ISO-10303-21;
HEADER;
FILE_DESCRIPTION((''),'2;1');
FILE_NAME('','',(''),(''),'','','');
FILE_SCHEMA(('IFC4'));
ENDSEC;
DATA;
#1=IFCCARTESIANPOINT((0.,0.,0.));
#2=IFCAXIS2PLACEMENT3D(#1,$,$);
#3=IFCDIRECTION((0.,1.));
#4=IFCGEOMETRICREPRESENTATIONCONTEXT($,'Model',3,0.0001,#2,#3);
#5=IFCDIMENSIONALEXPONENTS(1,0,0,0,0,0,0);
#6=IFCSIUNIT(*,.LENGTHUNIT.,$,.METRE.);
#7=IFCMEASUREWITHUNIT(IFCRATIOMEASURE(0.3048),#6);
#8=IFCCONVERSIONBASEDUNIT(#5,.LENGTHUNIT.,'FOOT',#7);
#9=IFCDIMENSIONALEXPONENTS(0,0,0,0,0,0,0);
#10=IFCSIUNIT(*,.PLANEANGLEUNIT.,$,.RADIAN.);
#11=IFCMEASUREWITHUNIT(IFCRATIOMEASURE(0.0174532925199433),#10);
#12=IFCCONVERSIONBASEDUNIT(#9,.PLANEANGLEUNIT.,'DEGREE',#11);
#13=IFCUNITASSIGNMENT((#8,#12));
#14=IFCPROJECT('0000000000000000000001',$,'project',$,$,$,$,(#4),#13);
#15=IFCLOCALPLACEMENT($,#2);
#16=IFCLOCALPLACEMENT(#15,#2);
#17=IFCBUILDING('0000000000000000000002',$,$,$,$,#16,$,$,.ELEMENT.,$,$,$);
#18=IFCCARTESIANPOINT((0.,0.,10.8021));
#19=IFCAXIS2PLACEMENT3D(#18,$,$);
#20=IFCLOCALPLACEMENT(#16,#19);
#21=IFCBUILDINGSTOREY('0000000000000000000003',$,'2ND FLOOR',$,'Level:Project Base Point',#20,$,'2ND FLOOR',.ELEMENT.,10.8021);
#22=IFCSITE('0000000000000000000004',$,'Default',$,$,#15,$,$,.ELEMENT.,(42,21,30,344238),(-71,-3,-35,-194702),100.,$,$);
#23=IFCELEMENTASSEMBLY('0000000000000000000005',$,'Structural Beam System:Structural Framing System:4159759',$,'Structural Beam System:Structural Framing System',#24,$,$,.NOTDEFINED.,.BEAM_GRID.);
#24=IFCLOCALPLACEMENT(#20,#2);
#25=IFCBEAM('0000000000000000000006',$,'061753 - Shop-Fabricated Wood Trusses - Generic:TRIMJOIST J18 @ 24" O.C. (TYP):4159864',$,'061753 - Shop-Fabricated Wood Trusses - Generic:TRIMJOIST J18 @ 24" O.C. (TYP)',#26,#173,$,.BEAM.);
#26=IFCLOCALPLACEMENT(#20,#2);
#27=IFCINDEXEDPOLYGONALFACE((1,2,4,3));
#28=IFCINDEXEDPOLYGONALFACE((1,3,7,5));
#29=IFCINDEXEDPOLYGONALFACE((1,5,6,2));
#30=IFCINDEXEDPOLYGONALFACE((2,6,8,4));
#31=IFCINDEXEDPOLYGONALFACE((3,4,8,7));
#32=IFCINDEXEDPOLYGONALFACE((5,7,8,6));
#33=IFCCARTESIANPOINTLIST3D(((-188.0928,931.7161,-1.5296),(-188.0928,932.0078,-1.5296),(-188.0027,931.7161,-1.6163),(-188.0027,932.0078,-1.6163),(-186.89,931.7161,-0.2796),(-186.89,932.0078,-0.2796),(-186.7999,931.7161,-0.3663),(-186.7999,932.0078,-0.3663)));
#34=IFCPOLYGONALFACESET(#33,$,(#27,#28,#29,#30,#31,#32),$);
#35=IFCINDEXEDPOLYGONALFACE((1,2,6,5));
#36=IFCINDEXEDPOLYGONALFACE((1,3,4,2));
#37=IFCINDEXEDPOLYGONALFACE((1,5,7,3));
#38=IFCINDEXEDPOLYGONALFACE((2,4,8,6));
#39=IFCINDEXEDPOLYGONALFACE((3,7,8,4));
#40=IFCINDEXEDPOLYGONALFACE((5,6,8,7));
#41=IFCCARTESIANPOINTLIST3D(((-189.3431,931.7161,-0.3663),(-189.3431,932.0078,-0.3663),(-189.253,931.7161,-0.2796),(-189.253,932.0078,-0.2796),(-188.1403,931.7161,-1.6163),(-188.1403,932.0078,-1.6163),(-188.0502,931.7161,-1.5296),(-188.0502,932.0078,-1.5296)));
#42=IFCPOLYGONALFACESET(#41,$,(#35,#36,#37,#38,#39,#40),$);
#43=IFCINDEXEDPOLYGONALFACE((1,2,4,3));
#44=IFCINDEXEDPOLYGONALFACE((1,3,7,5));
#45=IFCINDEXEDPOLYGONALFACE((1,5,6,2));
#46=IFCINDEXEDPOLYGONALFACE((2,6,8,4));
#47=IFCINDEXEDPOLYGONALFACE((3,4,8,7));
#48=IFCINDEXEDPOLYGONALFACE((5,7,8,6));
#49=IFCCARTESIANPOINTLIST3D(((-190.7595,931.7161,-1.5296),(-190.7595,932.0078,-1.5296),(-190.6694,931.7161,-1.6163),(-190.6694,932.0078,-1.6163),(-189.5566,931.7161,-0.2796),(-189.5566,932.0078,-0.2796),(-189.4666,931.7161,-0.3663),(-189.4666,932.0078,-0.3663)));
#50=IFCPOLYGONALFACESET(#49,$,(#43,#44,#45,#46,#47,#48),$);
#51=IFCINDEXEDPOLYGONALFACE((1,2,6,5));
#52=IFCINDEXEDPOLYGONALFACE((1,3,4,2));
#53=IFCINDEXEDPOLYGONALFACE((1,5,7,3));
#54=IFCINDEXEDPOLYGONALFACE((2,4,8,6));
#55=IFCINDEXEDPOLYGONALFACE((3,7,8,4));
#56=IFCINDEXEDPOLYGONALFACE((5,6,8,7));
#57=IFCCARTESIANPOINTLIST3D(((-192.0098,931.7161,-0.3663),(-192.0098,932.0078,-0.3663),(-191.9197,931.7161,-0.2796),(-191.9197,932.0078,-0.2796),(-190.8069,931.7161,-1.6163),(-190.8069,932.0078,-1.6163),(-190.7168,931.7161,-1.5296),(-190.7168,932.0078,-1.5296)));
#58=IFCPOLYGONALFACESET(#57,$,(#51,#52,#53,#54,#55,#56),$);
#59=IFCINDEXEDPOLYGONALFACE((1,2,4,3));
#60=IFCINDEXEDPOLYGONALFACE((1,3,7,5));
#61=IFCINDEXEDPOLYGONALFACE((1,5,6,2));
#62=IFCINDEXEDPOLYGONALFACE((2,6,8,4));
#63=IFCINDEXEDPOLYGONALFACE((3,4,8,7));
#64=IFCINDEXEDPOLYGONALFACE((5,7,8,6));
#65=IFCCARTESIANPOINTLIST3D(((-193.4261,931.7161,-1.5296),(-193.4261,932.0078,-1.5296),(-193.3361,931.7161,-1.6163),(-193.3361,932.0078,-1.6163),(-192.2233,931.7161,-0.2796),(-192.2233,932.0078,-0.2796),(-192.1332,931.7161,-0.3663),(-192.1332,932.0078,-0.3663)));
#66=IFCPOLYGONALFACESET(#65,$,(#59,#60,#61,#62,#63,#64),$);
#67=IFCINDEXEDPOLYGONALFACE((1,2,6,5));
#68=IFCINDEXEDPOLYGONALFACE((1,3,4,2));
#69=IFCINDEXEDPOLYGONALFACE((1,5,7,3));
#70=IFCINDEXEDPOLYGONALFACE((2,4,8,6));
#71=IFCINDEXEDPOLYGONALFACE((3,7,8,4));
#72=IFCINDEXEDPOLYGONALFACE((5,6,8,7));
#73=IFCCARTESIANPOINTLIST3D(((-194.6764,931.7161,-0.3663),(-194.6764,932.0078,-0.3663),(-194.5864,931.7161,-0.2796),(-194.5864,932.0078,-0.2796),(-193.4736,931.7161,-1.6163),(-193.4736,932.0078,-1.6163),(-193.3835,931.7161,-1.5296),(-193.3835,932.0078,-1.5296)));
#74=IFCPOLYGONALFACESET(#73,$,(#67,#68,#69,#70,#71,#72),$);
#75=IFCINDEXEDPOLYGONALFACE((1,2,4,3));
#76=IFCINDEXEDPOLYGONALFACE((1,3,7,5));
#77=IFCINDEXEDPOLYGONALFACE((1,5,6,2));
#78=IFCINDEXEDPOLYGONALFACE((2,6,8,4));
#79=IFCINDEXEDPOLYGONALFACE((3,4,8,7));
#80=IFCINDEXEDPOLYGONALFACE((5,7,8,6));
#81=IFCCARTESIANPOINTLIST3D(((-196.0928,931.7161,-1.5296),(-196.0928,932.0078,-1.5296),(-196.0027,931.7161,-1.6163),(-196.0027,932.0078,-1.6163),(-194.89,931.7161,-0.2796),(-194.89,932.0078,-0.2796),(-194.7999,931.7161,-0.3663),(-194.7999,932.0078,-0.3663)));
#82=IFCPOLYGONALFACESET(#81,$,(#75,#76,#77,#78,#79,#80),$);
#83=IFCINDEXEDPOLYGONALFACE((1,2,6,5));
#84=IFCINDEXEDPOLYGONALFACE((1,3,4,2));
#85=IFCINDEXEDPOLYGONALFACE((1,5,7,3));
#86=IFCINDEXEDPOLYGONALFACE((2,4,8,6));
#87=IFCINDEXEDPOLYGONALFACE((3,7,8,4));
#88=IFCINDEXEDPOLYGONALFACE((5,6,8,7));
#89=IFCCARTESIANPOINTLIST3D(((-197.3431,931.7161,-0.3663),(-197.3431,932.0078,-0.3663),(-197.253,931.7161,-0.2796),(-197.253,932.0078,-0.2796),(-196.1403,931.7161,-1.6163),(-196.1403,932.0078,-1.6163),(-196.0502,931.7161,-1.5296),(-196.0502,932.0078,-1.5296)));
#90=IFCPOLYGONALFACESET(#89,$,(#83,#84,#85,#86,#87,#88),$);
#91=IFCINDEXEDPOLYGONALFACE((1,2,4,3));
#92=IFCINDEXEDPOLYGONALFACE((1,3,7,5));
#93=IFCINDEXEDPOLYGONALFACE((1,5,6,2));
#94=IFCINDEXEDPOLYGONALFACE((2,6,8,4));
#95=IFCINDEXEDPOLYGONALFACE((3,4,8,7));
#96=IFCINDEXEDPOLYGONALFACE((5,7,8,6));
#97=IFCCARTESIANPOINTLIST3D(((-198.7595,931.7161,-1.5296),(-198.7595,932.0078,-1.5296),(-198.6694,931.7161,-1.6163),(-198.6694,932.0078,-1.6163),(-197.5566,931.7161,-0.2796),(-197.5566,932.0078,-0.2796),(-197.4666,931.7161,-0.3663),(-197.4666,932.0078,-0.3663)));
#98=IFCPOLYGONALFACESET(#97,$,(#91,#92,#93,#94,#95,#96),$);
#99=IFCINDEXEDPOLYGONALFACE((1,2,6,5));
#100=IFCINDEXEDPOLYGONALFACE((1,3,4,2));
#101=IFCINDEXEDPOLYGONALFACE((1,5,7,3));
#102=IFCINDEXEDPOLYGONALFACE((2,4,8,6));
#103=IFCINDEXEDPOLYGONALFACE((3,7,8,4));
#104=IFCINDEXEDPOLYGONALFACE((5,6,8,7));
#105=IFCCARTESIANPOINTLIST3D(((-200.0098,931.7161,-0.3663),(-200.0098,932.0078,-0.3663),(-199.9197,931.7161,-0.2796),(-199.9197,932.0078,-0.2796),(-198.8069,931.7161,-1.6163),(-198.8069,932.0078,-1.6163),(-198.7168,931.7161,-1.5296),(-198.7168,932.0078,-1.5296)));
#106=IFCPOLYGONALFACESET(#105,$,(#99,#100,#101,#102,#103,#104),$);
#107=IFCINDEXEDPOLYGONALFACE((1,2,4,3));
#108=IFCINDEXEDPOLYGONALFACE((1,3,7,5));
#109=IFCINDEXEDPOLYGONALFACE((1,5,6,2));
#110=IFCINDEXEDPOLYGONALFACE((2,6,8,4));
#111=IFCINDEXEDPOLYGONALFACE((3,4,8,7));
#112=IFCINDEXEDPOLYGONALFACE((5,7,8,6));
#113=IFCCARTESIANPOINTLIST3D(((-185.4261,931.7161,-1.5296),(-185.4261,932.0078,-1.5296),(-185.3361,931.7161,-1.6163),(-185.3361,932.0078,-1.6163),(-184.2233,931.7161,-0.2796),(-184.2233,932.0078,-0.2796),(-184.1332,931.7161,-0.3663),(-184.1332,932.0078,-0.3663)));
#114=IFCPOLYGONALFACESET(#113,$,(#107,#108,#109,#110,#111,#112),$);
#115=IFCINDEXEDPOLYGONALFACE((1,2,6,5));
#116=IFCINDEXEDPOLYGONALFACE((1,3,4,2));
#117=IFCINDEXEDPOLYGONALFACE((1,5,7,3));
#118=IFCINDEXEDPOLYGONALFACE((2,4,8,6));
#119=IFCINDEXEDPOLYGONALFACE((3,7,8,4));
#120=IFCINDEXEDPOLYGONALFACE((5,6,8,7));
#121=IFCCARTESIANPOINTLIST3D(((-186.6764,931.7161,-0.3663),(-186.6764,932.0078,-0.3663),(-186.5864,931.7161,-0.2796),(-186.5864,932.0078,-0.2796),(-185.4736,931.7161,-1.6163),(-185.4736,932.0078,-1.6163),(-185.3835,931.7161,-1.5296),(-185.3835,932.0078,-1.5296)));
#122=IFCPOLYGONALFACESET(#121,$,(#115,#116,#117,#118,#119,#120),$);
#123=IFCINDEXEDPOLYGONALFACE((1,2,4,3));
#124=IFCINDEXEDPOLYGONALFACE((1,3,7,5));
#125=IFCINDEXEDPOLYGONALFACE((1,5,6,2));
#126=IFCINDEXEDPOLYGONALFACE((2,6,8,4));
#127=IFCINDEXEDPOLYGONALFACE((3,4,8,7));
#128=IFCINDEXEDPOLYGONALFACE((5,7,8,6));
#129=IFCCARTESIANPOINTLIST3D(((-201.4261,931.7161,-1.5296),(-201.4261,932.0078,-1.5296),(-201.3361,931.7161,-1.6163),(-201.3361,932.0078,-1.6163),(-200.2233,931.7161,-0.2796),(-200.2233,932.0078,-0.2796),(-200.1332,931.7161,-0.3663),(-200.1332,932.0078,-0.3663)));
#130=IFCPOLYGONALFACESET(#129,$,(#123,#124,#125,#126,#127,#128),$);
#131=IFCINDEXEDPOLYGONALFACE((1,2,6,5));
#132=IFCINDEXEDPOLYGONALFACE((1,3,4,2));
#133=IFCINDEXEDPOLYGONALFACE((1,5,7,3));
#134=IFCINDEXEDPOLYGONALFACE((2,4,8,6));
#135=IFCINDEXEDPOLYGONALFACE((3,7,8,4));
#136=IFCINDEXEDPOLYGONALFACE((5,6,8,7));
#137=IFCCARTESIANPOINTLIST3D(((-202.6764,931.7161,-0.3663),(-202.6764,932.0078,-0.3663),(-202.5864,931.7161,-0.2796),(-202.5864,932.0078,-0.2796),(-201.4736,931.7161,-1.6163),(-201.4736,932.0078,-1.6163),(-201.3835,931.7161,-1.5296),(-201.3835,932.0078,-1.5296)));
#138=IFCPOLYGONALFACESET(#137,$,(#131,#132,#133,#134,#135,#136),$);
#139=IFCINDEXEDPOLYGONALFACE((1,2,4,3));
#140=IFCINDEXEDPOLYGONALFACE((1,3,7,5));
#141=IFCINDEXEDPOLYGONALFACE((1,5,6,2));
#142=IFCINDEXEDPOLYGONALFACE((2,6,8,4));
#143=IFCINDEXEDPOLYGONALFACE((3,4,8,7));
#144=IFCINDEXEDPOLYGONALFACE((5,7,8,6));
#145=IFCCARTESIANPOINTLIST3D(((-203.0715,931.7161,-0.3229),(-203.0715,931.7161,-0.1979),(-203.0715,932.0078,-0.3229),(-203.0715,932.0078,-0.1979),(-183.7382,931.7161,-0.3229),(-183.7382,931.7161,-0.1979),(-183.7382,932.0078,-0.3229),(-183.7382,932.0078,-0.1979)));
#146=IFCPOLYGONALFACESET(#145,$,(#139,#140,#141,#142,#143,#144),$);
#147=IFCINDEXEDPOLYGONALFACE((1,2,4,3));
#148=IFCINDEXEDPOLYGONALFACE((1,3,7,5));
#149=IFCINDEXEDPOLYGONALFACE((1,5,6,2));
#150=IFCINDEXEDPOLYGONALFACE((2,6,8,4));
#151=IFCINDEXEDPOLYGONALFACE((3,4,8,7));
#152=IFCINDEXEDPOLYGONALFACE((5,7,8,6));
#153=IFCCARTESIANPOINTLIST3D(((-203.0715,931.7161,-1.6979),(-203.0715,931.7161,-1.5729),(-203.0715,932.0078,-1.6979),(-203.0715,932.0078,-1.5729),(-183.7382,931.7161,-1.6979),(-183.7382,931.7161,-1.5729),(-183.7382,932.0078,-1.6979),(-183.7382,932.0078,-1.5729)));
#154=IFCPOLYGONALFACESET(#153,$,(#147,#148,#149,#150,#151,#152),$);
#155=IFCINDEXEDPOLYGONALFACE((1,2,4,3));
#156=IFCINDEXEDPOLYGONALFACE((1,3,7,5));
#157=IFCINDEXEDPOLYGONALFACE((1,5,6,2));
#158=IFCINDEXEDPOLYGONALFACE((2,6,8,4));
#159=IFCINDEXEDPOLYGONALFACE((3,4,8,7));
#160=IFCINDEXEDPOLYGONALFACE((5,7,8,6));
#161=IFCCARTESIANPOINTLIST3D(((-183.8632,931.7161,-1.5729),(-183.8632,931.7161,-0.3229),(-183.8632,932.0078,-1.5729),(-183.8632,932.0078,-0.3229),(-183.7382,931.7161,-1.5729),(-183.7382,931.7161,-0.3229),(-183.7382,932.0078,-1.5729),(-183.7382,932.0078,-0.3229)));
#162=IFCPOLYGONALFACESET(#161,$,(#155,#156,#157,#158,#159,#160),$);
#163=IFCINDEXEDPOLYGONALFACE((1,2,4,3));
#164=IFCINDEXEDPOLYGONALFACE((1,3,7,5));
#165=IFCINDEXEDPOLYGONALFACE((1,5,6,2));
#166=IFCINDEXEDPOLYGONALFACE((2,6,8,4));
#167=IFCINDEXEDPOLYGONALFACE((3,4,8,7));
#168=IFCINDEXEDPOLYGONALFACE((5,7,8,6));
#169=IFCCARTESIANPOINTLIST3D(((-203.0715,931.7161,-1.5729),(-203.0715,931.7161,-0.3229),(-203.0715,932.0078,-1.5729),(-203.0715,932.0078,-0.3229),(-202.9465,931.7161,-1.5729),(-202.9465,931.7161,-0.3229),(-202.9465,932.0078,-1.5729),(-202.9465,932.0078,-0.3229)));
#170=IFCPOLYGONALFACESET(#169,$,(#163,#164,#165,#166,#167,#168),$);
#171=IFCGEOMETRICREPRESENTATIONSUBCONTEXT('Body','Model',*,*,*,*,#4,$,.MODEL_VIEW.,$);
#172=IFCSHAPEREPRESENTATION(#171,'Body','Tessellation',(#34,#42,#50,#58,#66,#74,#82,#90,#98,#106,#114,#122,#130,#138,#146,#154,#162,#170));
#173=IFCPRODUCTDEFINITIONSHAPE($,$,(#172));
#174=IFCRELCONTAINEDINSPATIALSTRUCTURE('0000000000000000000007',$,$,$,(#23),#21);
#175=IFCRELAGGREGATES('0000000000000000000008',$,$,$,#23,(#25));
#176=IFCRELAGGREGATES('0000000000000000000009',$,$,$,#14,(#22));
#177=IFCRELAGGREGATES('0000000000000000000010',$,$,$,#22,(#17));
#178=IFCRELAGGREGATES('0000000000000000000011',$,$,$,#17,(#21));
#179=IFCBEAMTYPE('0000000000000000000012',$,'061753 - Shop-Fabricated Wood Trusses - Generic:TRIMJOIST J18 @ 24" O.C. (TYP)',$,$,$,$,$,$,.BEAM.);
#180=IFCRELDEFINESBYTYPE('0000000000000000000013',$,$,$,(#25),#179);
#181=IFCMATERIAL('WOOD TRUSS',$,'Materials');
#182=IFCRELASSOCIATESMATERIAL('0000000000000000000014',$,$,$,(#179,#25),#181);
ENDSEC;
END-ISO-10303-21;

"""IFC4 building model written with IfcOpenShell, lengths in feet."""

from ifc_helpers import new_model, entity, si_unit, converted_unit, direction, frame, frame_2d, origin, origin_2d_with_axis, place, context, subcontext, project, spatial, rectangle, extrude, source, transform, mapped, material, material_profile, profile_set, profile_usage, type_object, type_shapes, element, aggregate, save


model = new_model("IFC4")

# Units and contexts
model_context = context("Model", 3, precision=0.0001, world=origin(), true_north=direction((0.0, 1.0)))
body_context = subcontext(model_context, "Body", "Model", "MODEL_VIEW")
ifc_project = project(units=[converted_unit("LENGTHUNIT", "FOOT", entity("IfcRatioMeasure", 0.3048), si_unit("LENGTHUNIT", "METRE"), dimensions=[1, 0, 0, 0, 0, 0, 0]), converted_unit("PLANEANGLEUNIT", "DEGREE", entity("IfcRatioMeasure", 0.0174532925199433), si_unit("PLANEANGLEUNIT", "RADIAN"), dimensions=[0, 0, 0, 0, 0, 0, 0])], contexts=[model_context])

# Site, building, storey
site_placement = place(None, origin())
site = spatial("IfcSite", under=ifc_project, at=site_placement, Name="Default", CompositionType="ELEMENT", RefLatitude=(42, 21, 30, 344238), RefLongitude=(-71, -3, -35, -194702), RefElevation=100.0)
building_placement = place(site_placement, origin())
building = spatial("IfcBuilding", under=site, at=building_placement, CompositionType="ELEMENT")
storey_placement = place(building_placement, frame((0.0, 0.0, 10.8021)))
storey = spatial("IfcBuildingStorey", under=building, at=storey_placement, Name="2ND FLOOR", ObjectType="Level:Project Base Point", LongName="2ND FLOOR", CompositionType="ELEMENT", Elevation=10.8021)

# Element assembly, beam
ifc_material_1 = material(Name="WOOD TRUSS", Category="Materials")
ifc_material_profile_1 = material_profile(ifc_material_1, rectangle(XDim=1.7347, YDim=0.125, at=frame_2d((0.0, 0.0), x_axis=(1.0, 0.0))), Name="TRIMJOIST J18 @ 24\" O.C. (TYP)")
ifc_material_profile_2 = material_profile(ifc_material_1, rectangle(XDim=1.7347, YDim=0.125, at=frame_2d((0.0, 0.0), x_axis=(1.0, 0.0))), Name="TRIMJOIST J18 @ 24\" O.C. (TYP)")
ifc_material_profile_3 = material_profile(ifc_material_1, rectangle(XDim=1.7347, YDim=0.125, at=frame_2d((0.0, 0.0), x_axis=(1.0, 0.0))), Name="TRIMJOIST J18 @ 24\" O.C. (TYP)")
ifc_material_profile_4 = material_profile(ifc_material_1, rectangle(XDim=1.7347, YDim=0.125, at=frame_2d((0.0, 0.0), x_axis=(1.0, 0.0))), Name="TRIMJOIST J18 @ 24\" O.C. (TYP)")
ifc_material_profile_5 = material_profile(ifc_material_1, rectangle(XDim=1.7347, YDim=0.125, at=frame_2d((0.0, 0.0), x_axis=(1.0, 0.0))), Name="TRIMJOIST J18 @ 24\" O.C. (TYP)")
ifc_material_profile_6 = material_profile(ifc_material_1, rectangle(XDim=1.7347, YDim=0.125, at=frame_2d((0.0, 0.0), x_axis=(1.0, 0.0))), Name="TRIMJOIST J18 @ 24\" O.C. (TYP)")
ifc_material_profile_7 = material_profile(ifc_material_1, rectangle(XDim=1.7347, YDim=0.125, at=frame_2d((0.0, 0.0), x_axis=(1.0, 0.0))), Name="TRIMJOIST J18 @ 24\" O.C. (TYP)")
ifc_material_profile_8 = material_profile(ifc_material_1, rectangle(XDim=1.7347, YDim=0.125, at=frame_2d((0.0, 0.0), x_axis=(1.0, 0.0))), Name="TRIMJOIST J18 @ 24\" O.C. (TYP)")
ifc_material_profile_9 = material_profile(ifc_material_1, rectangle(XDim=1.7347, YDim=0.125, at=frame_2d((0.0, 0.0), x_axis=(1.0, 0.0))), Name="TRIMJOIST J18 @ 24\" O.C. (TYP)")
ifc_material_profile_10 = material_profile(ifc_material_1, rectangle(XDim=1.7347, YDim=0.125, at=origin_2d_with_axis()), Name="TRIMJOIST J18 @ 24\" O.C. (TYP)")
ifc_material_profile_11 = material_profile(ifc_material_1, rectangle(XDim=0.125, YDim=0.2917, at=origin_2d_with_axis()), Name="TRIMJOIST J18 @ 24\" O.C. (TYP)")
ifc_material_profile_12 = material_profile(ifc_material_1, rectangle(XDim=0.125, YDim=0.2917, at=origin_2d_with_axis()), Name="TRIMJOIST J18 @ 24\" O.C. (TYP)")
ifc_material_profile_13 = material_profile(ifc_material_1, rectangle(XDim=1.25, YDim=0.2917, at=origin_2d_with_axis()), Name="TRIMJOIST J18 @ 24\" O.C. (TYP)")
ifc_material_profile_14 = material_profile(ifc_material_1, rectangle(XDim=1.25, YDim=0.2917, at=origin_2d_with_axis()), Name="TRIMJOIST J18 @ 24\" O.C. (TYP)")
ifc_profile_set_1 = profile_set([ifc_material_profile_1, ifc_material_profile_2, ifc_material_profile_3, ifc_material_profile_4, ifc_material_profile_5, ifc_material_profile_6, ifc_material_profile_7, ifc_material_profile_8, ifc_material_profile_9, ifc_material_profile_10, ifc_material_profile_11, ifc_material_profile_12, ifc_material_profile_13, ifc_material_profile_14], Name="TRIMJOIST J18 @ 24\" O.C. (TYP)")
beam_type_1 = type_object("IfcBeamType", Name="061753 - Shop-Fabricated Wood Trusses - Generic:TRIMJOIST J18 @ 24\" O.C. (TYP)", PredefinedType="BEAM", material=ifc_profile_set_1)
shared_shape_1 = source(origin(), body_context, "Body", "SweptSolid", [
    extrude(rectangle(XDim=1.7347, YDim=0.125, at=frame_2d((0.0, 0.0), x_axis=(1.0, 0.0))), frame((5.9585, -0.1458, 0.0), z_axis=(0.0, 1.0, 0.0), x_axis=(0.693383, 0.0, 0.720569)), (0.0, 0.0, 1.0), 0.2917),
    extrude(rectangle(XDim=1.7347, YDim=0.125, at=origin_2d_with_axis()), frame((4.7082, -0.1458, 0.0), z_axis=(0.0, 1.0, 0.0), x_axis=(0.693383, 0.0, -0.720569)), (0.0, 0.0, 1.0), 0.2917),
    extrude(rectangle(XDim=1.7347, YDim=0.125, at=frame_2d((0.0, 0.0), x_axis=(1.0, 0.0))), frame((3.2918, -0.1458, 0.0), z_axis=(0.0, 1.0, 0.0), x_axis=(0.693383, 0.0, 0.720569)), (0.0, 0.0, 1.0), 0.2917),
    extrude(rectangle(XDim=1.7347, YDim=0.125, at=frame_2d((0.0, 0.0), x_axis=(1.0, 0.0))), frame((2.0415, -0.1458, 0.0), z_axis=(0.0, 1.0, 0.0), x_axis=(0.693383, 0.0, -0.720569)), (0.0, 0.0, 1.0), 0.2917),
    extrude(rectangle(XDim=1.7347, YDim=0.125, at=frame_2d((0.0, 0.0), x_axis=(1.0, 0.0))), frame((0.6251, -0.1458, 0.0), z_axis=(0.0, 1.0, 0.0), x_axis=(0.693383, 0.0, 0.720569)), (0.0, 0.0, 1.0), 0.2917),
    extrude(rectangle(XDim=1.7347, YDim=0.125, at=frame_2d((0.0, 0.0), x_axis=(1.0, 0.0))), frame((-0.6251, -0.1458, 0.0), z_axis=(0.0, 1.0, 0.0), x_axis=(0.693383, 0.0, -0.720569)), (0.0, 0.0, 1.0), 0.2917),
    extrude(rectangle(XDim=1.7347, YDim=0.125, at=frame_2d((0.0, 0.0), x_axis=(1.0, 0.0))), frame((-2.0415, -0.1458, 0.0), z_axis=(0.0, 1.0, 0.0), x_axis=(0.693383, 0.0, 0.720569)), (0.0, 0.0, 1.0), 0.2917),
    extrude(rectangle(XDim=1.7347, YDim=0.125, at=origin_2d_with_axis()), frame((-3.2918, -0.1458, 0.0), z_axis=(0.0, 1.0, 0.0), x_axis=(0.693383, 0.0, -0.720569)), (0.0, 0.0, 1.0), 0.2917),
    extrude(rectangle(XDim=1.7347, YDim=0.125, at=frame_2d((0.0, 0.0), x_axis=(1.0, 0.0))), frame((-4.7082, -0.1458, 0.0), z_axis=(0.0, 1.0, 0.0), x_axis=(0.693383, 0.0, 0.720569)), (0.0, 0.0, 1.0), 0.2917),
    extrude(rectangle(XDim=1.7347, YDim=0.125, at=frame_2d((0.0, 0.0), x_axis=(1.0, 0.0))), frame((-5.9585, -0.1458, 0.0), z_axis=(0.0, 1.0, 0.0), x_axis=(0.693383, 0.0, -0.720569)), (0.0, 0.0, 1.0), 0.2917),
    extrude(rectangle(XDim=1.7347, YDim=0.125, at=frame_2d((0.0, 0.0), x_axis=(1.0, 0.0))), frame((8.6251, -0.1458, 0.0), z_axis=(0.0, 1.0, 0.0), x_axis=(0.693383, 0.0, 0.720569)), (0.0, 0.0, 1.0), 0.2917),
    extrude(rectangle(XDim=1.7347, YDim=0.125, at=origin_2d_with_axis()), frame((7.3749, -0.1458, 0.0), z_axis=(0.0, 1.0, 0.0), x_axis=(0.693383, 0.0, -0.720569)), (0.0, 0.0, 1.0), 0.2917),
    extrude(rectangle(XDim=1.7347, YDim=0.125, at=frame_2d((0.0, 0.0), x_axis=(1.0, 0.0))), frame((-7.3749, -0.1458, 0.0), z_axis=(0.0, 1.0, 0.0), x_axis=(0.693383, 0.0, 0.720569)), (0.0, 0.0, 1.0), 0.2917),
    extrude(rectangle(XDim=1.7347, YDim=0.125, at=origin_2d_with_axis()), frame((-8.6251, -0.1458, 0.0), z_axis=(0.0, 1.0, 0.0), x_axis=(0.693383, 0.0, -0.720569)), (0.0, 0.0, 1.0), 0.2917),
    extrude(rectangle(XDim=0.125, YDim=0.2917, at=origin_2d_with_axis()), frame((-9.6667, 0.0, 0.6875), z_axis=(1.0, 0.0, 0.0), x_axis=(0.0, 0.0, -1.0)), (0.0, 0.0, 1.0), 19.3333),
    extrude(rectangle(XDim=0.125, YDim=0.2917, at=origin_2d_with_axis()), frame((-9.6667, 0.0, -0.6875), z_axis=(1.0, 0.0, 0.0), x_axis=(0.0, 0.0, -1.0)), (0.0, 0.0, 1.0), 19.3333),
    extrude(rectangle(XDim=1.25, YDim=0.2917, at=origin_2d_with_axis()), frame((9.5417, 0.0, 0.0), z_axis=(1.0, 0.0, 0.0), x_axis=(0.0, 0.0, -1.0)), (0.0, 0.0, 1.0), 0.125),
    extrude(rectangle(XDim=1.25, YDim=0.2917, at=origin_2d_with_axis()), frame((-9.6667, 0.0, 0.0), z_axis=(1.0, 0.0, 0.0), x_axis=(0.0, 0.0, -1.0)), (0.0, 0.0, 1.0), 0.125),
])
type_shapes(beam_type_1, [shared_shape_1])
assembly_1_placement = place(storey_placement, origin())
assembly_1 = element("IfcElementAssembly", 1, at=assembly_1_placement, inside=storey, Name="Structural Beam System:Structural Framing System:4159759", ObjectType="Structural Beam System:Structural Framing System", AssemblyPlace="NOTDEFINED", PredefinedType="BEAM_GRID")
ifc_profile_usage_1 = profile_usage(ifc_profile_set_1, cardinal=8)
beam_1_placement = place(assembly_1_placement, frame((-193.4048, 931.8619, -0.9479)))
beam_1 = element("IfcBeam", 2, at=beam_1_placement, type_object=beam_type_1, material=ifc_profile_usage_1, Name="061753 - Shop-Fabricated Wood Trusses - Generic:TRIMJOIST J18 @ 24\" O.C. (TYP):4159864", ObjectType="061753 - Shop-Fabricated Wood Trusses - Generic:TRIMJOIST J18 @ 24\" O.C. (TYP)", PredefinedType="BEAM", context=body_context, shape_type="MappedRepresentation", body=[
    mapped(shared_shape_1, transform((0.0, 0.0, 0.0), scale=1.0)),
])
aggregate(assembly_1, [beam_1])

save(model, "model.ifc")
